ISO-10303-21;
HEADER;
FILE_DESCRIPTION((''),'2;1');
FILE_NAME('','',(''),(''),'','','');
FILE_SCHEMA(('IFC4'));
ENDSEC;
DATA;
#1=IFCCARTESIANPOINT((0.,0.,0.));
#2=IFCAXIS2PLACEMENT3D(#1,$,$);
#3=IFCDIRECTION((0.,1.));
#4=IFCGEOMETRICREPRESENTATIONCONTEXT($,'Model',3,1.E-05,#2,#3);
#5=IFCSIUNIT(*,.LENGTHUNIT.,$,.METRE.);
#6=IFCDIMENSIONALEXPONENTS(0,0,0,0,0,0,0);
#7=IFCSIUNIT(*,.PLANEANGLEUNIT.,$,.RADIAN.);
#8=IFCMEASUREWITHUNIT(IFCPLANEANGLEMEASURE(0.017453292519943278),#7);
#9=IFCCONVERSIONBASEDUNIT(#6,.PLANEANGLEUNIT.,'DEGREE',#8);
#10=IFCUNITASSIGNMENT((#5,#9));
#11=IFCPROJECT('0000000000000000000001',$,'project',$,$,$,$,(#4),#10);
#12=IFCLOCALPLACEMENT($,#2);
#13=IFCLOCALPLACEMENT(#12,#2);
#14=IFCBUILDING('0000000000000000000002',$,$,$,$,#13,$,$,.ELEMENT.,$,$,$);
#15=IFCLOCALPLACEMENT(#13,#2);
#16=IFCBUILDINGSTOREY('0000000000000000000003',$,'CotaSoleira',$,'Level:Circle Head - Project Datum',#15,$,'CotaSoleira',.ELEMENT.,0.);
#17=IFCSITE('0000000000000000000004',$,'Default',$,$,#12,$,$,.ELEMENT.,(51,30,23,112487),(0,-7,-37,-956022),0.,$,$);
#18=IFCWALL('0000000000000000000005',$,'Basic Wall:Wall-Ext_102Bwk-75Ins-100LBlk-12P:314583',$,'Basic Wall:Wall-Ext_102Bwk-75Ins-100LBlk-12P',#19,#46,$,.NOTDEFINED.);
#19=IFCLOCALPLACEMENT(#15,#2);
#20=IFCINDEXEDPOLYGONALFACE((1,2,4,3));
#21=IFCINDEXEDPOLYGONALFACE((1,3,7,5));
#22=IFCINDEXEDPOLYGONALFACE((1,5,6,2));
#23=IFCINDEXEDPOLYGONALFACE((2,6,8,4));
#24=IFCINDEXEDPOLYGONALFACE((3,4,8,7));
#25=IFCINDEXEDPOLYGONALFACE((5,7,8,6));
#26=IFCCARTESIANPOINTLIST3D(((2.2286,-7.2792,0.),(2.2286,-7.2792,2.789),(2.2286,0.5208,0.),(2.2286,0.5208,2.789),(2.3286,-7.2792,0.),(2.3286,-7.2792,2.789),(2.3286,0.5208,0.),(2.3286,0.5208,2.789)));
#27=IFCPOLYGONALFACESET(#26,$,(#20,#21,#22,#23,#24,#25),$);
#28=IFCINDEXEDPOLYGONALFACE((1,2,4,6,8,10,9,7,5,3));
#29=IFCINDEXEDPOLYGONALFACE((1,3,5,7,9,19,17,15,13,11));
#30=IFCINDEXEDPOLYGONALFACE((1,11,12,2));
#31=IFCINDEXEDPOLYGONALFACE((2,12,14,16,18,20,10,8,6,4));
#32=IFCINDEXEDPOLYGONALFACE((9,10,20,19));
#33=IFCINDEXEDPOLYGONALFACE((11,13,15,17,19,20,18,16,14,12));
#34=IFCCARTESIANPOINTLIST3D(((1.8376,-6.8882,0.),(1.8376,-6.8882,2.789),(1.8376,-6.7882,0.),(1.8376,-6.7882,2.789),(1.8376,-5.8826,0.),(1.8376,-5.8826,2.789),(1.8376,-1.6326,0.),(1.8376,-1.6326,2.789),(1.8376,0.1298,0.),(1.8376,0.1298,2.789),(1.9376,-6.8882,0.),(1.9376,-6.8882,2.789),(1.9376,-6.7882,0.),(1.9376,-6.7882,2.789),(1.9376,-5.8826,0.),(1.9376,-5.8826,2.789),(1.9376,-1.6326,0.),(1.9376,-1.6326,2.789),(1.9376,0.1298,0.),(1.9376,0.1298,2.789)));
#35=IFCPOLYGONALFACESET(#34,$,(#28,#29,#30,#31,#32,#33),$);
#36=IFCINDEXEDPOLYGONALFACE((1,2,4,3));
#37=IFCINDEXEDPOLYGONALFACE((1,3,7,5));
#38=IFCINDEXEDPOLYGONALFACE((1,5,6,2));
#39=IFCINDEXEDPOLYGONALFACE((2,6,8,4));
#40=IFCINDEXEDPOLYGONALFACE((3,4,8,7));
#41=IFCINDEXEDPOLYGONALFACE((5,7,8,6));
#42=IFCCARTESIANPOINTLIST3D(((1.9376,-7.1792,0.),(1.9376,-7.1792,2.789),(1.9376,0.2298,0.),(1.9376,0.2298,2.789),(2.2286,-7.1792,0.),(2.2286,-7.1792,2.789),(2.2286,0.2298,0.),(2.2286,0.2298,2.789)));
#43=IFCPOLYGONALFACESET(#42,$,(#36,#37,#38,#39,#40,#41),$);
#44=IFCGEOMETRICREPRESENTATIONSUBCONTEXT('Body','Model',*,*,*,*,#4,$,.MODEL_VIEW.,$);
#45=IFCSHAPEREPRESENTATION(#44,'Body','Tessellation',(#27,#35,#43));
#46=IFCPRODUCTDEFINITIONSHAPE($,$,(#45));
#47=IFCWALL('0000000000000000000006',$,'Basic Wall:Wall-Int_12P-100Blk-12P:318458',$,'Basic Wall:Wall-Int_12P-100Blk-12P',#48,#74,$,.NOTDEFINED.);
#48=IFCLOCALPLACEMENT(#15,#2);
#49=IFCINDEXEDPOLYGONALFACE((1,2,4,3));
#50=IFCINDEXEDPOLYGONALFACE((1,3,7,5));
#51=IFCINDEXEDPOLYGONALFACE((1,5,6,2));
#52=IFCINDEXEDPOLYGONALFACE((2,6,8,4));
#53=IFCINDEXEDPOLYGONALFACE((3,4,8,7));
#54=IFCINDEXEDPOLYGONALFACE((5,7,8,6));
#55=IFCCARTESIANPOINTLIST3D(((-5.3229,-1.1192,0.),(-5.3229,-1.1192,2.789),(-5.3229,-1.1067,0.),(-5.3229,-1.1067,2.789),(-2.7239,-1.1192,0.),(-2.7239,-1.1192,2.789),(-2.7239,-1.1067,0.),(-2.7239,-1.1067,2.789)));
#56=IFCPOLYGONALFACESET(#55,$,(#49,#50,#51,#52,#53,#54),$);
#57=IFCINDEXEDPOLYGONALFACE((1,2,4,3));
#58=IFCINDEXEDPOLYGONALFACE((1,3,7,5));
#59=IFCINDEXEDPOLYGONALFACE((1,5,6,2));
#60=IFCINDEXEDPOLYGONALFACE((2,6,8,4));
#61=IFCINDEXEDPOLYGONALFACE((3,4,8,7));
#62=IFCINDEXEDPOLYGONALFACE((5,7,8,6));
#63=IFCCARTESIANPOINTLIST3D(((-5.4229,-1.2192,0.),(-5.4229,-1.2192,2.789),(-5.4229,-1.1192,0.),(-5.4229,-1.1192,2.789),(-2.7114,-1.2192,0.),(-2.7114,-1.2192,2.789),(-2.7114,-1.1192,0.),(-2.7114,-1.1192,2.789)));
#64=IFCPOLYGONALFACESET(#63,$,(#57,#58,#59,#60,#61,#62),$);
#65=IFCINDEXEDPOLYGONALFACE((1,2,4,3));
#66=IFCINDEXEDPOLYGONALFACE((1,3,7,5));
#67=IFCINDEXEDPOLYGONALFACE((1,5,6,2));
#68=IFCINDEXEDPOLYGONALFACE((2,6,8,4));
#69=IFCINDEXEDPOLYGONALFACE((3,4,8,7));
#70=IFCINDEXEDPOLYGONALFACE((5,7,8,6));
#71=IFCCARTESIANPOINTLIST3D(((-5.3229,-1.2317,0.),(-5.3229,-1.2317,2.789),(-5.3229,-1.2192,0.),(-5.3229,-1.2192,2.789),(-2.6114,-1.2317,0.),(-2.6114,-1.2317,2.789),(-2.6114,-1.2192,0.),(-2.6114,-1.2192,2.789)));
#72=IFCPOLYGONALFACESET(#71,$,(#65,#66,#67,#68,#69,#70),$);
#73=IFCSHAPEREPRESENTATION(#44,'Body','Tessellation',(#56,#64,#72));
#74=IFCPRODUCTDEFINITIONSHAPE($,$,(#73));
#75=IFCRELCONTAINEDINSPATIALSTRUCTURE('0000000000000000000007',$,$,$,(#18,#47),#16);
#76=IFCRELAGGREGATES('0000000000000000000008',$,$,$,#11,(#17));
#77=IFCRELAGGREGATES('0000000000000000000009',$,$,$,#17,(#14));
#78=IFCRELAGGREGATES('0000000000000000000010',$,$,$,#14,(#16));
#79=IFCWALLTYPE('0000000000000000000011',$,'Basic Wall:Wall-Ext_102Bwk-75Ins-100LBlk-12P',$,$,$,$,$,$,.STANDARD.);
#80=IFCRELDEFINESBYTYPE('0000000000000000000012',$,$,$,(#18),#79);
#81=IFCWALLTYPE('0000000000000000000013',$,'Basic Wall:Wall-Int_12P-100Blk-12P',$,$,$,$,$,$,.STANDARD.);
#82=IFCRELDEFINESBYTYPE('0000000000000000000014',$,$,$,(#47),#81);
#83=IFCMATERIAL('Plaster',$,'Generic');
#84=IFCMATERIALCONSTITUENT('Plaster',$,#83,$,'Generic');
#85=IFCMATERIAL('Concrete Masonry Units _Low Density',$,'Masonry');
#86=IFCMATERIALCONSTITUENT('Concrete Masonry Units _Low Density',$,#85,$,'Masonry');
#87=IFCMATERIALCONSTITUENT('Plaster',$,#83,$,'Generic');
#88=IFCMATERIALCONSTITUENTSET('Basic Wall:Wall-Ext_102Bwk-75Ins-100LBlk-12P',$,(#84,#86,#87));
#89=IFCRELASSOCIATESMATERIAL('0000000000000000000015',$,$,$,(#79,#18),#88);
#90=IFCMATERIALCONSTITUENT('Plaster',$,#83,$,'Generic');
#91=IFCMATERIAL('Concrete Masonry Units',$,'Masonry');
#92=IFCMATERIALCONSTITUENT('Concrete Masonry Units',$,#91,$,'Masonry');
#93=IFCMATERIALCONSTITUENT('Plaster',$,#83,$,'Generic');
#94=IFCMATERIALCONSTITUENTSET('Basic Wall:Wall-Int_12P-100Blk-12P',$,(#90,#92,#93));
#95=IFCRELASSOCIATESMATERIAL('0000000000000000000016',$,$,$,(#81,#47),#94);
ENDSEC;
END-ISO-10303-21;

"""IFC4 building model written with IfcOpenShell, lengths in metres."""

from ifc_helpers import new_model, entity, si_unit, converted_unit, direction, frame, origin, place, context, subcontext, project, spatial, indexed_curve, outline, extrude, material, constituent, constituent_set, type_object, element, save


model = new_model("IFC4")

# Units and contexts
model_context = context("Model", 3, precision=1e-05, world=origin(), true_north=direction((0.0, 1.0)))
body_context = subcontext(model_context, "Body", "Model", "MODEL_VIEW")
ifc_project = project(units=[si_unit("LENGTHUNIT", "METRE"), converted_unit("PLANEANGLEUNIT", "DEGREE", entity("IfcPlaneAngleMeasure", 0.017453292519943278), si_unit("PLANEANGLEUNIT", "RADIAN"), dimensions=[0, 0, 0, 0, 0, 0, 0])], contexts=[model_context])

# Site, building, storey
site_placement = place(None, origin())
site = spatial("IfcSite", under=ifc_project, at=site_placement, Name="Default", CompositionType="ELEMENT", RefLatitude=(51, 30, 23, 112487), RefLongitude=(0, -7, -37, -956022), RefElevation=0.0)
building_placement = place(site_placement, origin())
building = spatial("IfcBuilding", under=site, at=building_placement, CompositionType="ELEMENT")
storey_placement = place(building_placement, origin())
storey = spatial("IfcBuildingStorey", under=building, at=storey_placement, Name="CotaSoleira", ObjectType="Level:Circle Head - Project Datum", LongName="CotaSoleira", CompositionType="ELEMENT", Elevation=0.0)

# Wall
ifc_material_1 = material(Name="Plaster", Category="Generic")
ifc_constituent_1 = constituent(ifc_material_1, Name="Plaster", Category="Generic")
ifc_material_2 = material(Name="Concrete Masonry Units _Low Density", Category="Masonry")
ifc_constituent_2 = constituent(ifc_material_2, Name="Concrete Masonry Units _Low Density", Category="Masonry")
ifc_constituent_3 = constituent(ifc_material_1, Name="Plaster", Category="Generic")
ifc_constituent_set_1 = constituent_set(constituents=[ifc_constituent_1, ifc_constituent_2, ifc_constituent_3], Name="Basic Wall:Wall-Ext_102Bwk-75Ins-100LBlk-12P")
wall_type_1 = type_object("IfcWallType", Name="Basic Wall:Wall-Ext_102Bwk-75Ins-100LBlk-12P", PredefinedType="STANDARD", material=ifc_constituent_set_1)
wall_1_placement = place(storey_placement, frame((2.0831, 0.1298, 0.0), z_axis=(0.0, 0.0, 1.0), x_axis=(0.0, -1.0, 0.0)))
element("IfcWall", 1, at=wall_1_placement, inside=storey, type_object=wall_type_1, material=ifc_constituent_set_1, Name="Basic Wall:Wall-Ext_102Bwk-75Ins-100LBlk-12P:314583", ObjectType="Basic Wall:Wall-Ext_102Bwk-75Ins-100LBlk-12P", PredefinedType="NOTDEFINED", context=body_context, shape_type="SweptSolid", body=[
    extrude(outline(indexed_curve([(-1.3945, -3.9), (1.3945, -3.9), (1.3945, 3.9), (-1.3945, 3.9), (-1.3945, -3.9)], self_intersect=False)), frame((3.509, 0.1455, 1.3945), z_axis=(0.0, 1.0, 0.0), x_axis=(0.0, 0.0, 1.0)), (0.0, 0.0, 1.0), 0.1),
    extrude(outline(indexed_curve([(-1.3945, -4.3422), (1.3945, -4.3422), (1.3945, -2.5797), (1.3945, 1.6703), (1.3945, 2.5758), (1.3945, 2.6758), (-1.3945, 2.6758), (-1.3945, 2.5758), (-1.3945, 1.6703), (-1.3945, -2.5797), (-1.3945, -4.3422)], self_intersect=False)), frame((4.3422, -0.2455, 1.3945), z_axis=(0.0, 1.0, 0.0), x_axis=(0.0, 0.0, 1.0)), (0.0, 0.0, 1.0), 0.1),
    extrude(outline(indexed_curve([(-1.3945, -3.7045), (1.3945, -3.7045), (1.3945, 3.7045), (-1.3945, 3.7045), (-1.3945, -3.7045)], self_intersect=False)), frame((3.6045, -0.1455, 1.3945), z_axis=(0.0, 1.0, 0.0), x_axis=(0.0, 0.0, 1.0)), (0.0, 0.0, 1.0), 0.291),
])

# Shared definitions
ifc_constituent_4 = constituent(ifc_material_1, Name="Plaster", Category="Generic")
ifc_material_3 = material(Name="Concrete Masonry Units", Category="Masonry")
ifc_constituent_5 = constituent(ifc_material_3, Name="Concrete Masonry Units", Category="Masonry")
ifc_constituent_6 = constituent(ifc_material_1, Name="Plaster", Category="Generic")
ifc_constituent_set_2 = constituent_set(constituents=[ifc_constituent_4, ifc_constituent_5, ifc_constituent_6], Name="Basic Wall:Wall-Int_12P-100Blk-12P")
wall_type_2 = type_object("IfcWallType", Name="Basic Wall:Wall-Int_12P-100Blk-12P", PredefinedType="STANDARD", material=ifc_constituent_set_2)

# Wall
wall_2_placement = place(storey_placement, frame((-2.7239, -1.1692, 0.0), z_axis=(0.0, 0.0, 1.0), x_axis=(-1.0, 0.0, 0.0)))
element("IfcWall", 2, at=wall_2_placement, inside=storey, type_object=wall_type_2, material=ifc_constituent_set_2, Name="Basic Wall:Wall-Int_12P-100Blk-12P:318458", ObjectType="Basic Wall:Wall-Int_12P-100Blk-12P", PredefinedType="NOTDEFINED", context=body_context, shape_type="SweptSolid", body=[
    extrude(outline(indexed_curve([(-0.0063, -1.2995), (0.0062, -1.2995), (0.0063, 1.2995), (-0.0062, 1.2995), (-0.0063, -1.2995)], self_intersect=False)), frame((1.2995, -0.0563, 0.0), z_axis=(0.0, 0.0, 1.0), x_axis=(0.0, 1.0, 0.0)), (0.0, 0.0, 1.0), 2.789),
    extrude(outline(indexed_curve([(-1.3558, -0.05), (1.3558, -0.05), (1.3558, 0.05), (-1.3558, 0.05), (-1.3558, -0.05)], self_intersect=False)), frame((1.3433, 0.0, 0.0)), (0.0, 0.0, 1.0), 2.789),
    extrude(outline(indexed_curve([(-0.0063, -1.3558), (0.0062, -1.3558), (0.0063, 1.3558), (-0.0062, 1.3558), (-0.0063, -1.3558)], self_intersect=False)), frame((1.2433, 0.0562, 0.0), z_axis=(0.0, 0.0, 1.0), x_axis=(0.0, -1.0, 0.0)), (0.0, 0.0, 1.0), 2.789),
])

save(model, "model.ifc")
